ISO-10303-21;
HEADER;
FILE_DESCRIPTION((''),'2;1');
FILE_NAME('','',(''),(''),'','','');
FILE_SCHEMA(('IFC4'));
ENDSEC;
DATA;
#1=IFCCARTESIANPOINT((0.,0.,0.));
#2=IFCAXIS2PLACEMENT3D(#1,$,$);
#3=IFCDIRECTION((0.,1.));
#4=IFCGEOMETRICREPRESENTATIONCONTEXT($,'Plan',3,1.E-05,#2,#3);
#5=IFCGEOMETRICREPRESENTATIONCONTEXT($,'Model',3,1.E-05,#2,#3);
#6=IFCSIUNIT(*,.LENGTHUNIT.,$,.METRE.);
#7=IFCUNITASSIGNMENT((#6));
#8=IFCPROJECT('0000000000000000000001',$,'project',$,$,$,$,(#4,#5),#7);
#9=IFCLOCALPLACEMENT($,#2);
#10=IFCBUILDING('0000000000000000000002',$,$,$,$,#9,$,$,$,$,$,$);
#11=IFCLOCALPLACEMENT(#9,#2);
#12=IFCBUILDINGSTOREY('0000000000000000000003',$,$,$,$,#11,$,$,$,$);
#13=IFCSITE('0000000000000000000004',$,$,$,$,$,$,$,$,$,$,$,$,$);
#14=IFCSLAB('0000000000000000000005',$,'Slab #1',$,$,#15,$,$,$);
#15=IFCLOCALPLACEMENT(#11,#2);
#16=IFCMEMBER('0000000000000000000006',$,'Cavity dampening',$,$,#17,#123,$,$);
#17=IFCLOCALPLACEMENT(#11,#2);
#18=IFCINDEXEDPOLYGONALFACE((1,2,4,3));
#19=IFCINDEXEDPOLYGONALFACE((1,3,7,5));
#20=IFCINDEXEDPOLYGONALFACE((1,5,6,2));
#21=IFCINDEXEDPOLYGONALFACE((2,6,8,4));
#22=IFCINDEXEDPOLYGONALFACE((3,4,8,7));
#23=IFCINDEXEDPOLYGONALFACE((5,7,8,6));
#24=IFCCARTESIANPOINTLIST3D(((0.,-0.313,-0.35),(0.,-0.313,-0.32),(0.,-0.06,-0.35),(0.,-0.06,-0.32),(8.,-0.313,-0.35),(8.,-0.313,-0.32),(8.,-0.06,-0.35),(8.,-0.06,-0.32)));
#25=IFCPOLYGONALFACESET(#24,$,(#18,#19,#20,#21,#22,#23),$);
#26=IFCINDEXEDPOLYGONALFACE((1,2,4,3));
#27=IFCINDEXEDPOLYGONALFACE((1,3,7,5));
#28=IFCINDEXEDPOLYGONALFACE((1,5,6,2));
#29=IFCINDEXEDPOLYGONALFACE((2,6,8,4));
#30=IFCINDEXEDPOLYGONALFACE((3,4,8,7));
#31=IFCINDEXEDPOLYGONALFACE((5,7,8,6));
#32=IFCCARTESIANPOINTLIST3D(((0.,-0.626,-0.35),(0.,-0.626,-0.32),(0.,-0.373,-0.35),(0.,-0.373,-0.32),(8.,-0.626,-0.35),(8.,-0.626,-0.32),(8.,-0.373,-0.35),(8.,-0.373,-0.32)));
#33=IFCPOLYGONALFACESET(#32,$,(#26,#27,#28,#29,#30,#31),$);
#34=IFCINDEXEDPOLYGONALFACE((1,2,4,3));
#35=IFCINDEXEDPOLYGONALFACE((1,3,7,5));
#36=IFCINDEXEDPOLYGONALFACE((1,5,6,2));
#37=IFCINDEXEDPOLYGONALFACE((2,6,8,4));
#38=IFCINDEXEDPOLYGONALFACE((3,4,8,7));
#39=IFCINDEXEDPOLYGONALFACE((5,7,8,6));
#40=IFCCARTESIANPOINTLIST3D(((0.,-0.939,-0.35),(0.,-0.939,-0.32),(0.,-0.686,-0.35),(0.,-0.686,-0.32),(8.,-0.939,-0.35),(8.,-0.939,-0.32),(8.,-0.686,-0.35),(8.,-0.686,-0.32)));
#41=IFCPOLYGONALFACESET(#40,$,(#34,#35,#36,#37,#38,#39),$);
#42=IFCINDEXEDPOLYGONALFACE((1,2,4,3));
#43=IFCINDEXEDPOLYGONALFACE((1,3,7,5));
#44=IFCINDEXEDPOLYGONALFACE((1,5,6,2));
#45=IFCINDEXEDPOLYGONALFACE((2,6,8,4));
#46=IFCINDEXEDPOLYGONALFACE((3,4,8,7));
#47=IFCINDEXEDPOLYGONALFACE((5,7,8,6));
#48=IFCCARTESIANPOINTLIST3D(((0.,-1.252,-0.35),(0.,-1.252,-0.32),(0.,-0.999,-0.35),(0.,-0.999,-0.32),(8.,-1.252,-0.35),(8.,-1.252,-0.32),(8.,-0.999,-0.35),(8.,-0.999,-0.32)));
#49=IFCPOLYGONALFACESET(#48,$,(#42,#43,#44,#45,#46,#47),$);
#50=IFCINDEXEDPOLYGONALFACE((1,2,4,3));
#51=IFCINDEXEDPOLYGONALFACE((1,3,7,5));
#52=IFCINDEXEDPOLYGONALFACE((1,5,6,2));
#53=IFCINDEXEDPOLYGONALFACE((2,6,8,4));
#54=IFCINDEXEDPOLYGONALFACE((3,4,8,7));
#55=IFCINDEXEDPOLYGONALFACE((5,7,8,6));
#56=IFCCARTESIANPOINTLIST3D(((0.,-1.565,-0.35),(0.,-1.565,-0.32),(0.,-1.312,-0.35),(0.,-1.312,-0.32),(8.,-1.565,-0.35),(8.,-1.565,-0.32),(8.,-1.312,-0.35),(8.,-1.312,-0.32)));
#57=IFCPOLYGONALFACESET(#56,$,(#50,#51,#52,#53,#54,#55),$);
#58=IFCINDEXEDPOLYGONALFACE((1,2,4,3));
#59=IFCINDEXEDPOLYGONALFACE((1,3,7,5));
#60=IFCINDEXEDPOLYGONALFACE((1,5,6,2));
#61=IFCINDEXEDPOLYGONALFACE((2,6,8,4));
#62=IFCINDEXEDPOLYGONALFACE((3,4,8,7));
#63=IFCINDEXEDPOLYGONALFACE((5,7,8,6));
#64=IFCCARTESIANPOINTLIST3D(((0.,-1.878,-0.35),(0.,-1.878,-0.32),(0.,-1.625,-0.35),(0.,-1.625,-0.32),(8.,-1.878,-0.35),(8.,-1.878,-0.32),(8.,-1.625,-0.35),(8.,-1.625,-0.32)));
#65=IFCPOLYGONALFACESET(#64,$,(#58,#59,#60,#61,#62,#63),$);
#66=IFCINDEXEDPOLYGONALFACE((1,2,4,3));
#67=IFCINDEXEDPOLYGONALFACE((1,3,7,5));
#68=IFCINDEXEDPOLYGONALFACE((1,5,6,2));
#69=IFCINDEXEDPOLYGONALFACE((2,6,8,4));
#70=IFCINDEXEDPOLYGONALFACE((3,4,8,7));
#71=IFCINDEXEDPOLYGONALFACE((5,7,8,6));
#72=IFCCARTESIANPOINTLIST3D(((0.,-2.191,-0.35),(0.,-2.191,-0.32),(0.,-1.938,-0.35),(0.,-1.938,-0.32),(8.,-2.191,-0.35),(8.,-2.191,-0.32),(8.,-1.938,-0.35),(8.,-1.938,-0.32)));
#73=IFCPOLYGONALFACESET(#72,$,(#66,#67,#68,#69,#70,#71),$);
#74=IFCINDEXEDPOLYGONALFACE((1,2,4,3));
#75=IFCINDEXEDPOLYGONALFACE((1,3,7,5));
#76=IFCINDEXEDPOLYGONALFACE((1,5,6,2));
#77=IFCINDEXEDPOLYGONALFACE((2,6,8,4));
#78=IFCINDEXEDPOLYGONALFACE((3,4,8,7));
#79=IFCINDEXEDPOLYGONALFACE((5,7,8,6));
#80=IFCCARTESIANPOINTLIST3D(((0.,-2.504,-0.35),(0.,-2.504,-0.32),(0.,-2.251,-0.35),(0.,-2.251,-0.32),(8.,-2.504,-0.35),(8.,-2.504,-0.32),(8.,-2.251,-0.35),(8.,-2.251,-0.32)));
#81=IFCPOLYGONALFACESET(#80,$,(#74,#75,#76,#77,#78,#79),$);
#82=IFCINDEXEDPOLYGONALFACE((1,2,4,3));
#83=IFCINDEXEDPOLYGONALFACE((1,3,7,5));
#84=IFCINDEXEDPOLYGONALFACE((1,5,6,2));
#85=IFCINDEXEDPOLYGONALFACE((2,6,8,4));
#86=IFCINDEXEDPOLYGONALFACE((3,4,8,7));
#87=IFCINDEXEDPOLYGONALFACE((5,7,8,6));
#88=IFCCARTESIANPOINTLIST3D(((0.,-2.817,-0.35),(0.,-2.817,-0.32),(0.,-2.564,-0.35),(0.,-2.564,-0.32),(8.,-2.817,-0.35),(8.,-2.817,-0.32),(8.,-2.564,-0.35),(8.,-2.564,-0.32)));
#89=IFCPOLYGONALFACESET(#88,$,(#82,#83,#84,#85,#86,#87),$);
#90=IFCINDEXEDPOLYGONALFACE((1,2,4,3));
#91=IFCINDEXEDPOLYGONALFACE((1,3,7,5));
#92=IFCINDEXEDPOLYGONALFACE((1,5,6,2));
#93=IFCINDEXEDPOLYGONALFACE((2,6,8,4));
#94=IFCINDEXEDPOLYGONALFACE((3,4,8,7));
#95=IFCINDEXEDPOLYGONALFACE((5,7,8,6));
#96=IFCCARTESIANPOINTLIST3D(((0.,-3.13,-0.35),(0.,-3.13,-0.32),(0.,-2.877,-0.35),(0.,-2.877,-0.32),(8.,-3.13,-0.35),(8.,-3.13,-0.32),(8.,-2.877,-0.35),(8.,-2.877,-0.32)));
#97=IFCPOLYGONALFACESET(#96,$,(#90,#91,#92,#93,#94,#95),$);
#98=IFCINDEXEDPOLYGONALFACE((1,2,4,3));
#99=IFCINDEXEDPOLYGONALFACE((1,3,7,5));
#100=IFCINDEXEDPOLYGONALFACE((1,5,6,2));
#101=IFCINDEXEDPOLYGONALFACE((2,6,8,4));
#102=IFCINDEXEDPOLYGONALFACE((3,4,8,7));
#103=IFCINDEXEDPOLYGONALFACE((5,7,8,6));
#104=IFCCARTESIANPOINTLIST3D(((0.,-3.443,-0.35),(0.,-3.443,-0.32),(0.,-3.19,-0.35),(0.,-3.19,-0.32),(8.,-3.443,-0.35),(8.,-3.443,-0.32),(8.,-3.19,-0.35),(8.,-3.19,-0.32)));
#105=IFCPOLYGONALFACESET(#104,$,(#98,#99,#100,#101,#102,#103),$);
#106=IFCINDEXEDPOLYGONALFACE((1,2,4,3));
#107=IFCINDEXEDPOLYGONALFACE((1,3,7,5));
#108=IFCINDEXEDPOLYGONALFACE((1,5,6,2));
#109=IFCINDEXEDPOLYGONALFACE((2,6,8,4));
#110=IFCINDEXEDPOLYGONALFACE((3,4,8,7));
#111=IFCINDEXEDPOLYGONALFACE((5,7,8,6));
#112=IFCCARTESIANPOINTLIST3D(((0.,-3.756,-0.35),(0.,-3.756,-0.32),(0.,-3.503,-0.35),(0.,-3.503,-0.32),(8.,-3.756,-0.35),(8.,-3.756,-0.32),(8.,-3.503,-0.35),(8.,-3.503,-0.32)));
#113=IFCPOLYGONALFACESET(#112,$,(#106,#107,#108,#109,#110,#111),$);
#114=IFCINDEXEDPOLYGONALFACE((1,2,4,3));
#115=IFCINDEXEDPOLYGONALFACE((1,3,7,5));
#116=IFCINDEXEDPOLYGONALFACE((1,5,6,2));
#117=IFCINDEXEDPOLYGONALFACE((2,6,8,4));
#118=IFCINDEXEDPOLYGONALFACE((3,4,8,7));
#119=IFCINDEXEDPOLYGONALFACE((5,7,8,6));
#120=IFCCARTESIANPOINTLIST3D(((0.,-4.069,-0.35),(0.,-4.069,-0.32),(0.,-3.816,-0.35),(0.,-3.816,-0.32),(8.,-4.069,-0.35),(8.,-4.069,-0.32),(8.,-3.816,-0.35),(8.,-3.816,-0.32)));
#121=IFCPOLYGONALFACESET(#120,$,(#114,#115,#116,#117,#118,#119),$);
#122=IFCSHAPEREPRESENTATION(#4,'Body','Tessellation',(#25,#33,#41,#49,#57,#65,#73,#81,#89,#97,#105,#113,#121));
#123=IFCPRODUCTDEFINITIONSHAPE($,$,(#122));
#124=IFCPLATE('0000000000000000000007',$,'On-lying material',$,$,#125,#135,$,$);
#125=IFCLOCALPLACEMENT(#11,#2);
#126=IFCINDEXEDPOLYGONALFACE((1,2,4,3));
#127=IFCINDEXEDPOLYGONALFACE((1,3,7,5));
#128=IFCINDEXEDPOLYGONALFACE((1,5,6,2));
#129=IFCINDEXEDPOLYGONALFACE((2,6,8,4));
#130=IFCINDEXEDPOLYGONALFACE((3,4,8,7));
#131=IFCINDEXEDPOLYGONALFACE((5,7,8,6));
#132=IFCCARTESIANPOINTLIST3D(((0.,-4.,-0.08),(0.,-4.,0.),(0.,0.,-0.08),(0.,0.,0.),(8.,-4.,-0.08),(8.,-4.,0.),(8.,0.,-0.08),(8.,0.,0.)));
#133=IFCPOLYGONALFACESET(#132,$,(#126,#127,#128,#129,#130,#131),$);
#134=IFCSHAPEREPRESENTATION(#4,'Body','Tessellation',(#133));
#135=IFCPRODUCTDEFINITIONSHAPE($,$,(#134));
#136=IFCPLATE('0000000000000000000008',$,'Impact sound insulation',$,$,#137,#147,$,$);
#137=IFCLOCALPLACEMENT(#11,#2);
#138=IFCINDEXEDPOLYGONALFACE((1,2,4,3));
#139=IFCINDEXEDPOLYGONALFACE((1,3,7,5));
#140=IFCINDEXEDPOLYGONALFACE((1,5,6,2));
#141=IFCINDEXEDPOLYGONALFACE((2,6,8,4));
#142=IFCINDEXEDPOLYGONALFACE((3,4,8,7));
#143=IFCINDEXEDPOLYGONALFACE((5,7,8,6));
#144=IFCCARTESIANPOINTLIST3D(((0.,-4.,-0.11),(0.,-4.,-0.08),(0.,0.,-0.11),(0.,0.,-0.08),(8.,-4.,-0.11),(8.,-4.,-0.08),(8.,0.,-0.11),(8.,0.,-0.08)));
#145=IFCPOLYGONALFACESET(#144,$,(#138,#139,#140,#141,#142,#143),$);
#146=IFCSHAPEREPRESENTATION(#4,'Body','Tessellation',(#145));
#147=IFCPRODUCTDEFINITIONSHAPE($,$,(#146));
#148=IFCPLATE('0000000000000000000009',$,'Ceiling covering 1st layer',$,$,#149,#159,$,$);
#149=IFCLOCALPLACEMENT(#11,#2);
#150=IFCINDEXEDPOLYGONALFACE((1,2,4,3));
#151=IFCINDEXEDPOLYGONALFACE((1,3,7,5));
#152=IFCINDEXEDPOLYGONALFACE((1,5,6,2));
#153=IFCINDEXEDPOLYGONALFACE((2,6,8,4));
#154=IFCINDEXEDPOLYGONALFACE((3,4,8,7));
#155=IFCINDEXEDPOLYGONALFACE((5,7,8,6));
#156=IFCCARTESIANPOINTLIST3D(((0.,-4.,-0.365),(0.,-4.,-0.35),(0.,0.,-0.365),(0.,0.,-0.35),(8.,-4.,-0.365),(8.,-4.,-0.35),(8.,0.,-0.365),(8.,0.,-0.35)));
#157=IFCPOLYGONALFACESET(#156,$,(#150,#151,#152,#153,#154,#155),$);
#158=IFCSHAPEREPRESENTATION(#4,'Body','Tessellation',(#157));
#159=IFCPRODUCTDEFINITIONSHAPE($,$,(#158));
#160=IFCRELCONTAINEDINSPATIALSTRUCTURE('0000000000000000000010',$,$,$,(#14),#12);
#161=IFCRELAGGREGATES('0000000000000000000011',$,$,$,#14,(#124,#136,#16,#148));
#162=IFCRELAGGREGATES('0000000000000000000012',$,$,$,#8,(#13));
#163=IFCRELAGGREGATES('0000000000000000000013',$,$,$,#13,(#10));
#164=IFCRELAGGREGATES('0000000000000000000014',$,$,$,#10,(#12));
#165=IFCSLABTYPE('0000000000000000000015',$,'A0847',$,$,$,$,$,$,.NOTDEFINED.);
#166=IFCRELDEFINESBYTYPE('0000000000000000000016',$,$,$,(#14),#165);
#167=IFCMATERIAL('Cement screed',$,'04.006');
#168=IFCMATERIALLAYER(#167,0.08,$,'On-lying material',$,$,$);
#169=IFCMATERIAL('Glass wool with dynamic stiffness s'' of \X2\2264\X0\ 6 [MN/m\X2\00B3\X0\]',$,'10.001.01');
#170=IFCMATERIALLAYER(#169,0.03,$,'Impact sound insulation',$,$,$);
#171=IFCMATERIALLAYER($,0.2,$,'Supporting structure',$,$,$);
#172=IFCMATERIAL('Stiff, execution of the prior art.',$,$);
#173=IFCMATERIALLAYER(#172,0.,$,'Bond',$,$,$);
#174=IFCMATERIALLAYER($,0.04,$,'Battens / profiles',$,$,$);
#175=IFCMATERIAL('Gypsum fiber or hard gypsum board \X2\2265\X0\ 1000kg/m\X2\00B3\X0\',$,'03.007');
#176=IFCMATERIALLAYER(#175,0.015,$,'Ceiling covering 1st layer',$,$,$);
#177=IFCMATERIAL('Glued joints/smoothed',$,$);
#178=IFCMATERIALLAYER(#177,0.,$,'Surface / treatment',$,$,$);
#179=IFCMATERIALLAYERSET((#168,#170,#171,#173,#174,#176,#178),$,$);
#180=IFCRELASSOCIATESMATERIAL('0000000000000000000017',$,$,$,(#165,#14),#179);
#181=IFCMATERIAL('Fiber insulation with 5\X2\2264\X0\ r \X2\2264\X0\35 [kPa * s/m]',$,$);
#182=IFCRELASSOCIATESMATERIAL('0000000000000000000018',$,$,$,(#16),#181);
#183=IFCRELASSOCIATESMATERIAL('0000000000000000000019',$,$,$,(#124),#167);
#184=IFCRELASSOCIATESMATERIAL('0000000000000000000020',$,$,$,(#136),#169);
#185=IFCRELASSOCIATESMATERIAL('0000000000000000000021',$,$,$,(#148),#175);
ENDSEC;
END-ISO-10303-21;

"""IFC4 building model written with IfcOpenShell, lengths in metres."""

from ifc_helpers import new_model, si_unit, direction, frame, frame_2d, origin, origin_with_axes, place, context, project, spatial, rectangle, extrude, material, layer, layer_set, type_object, element, aggregate, save


model = new_model("IFC4")

# Units and contexts
plan_context = context("Plan", 3, precision=1e-05, world=origin(), true_north=direction((0.0, 1.0)))
model_context = context("Model", 3, precision=1e-05, world=origin(), true_north=direction((0.0, 1.0)))
ifc_project = project(units=[si_unit("LENGTHUNIT", "METRE")], contexts=[plan_context, model_context])

# Site, building, storey
site = spatial("IfcSite", under=ifc_project)
building_placement = place(None, origin())
building = spatial("IfcBuilding", under=site, at=building_placement)
storey_placement = place(building_placement, origin())
storey = spatial("IfcBuildingStorey", under=building, at=storey_placement)

# Slab, member, plates
ifc_material_1 = material(Name="Cement screed", Category="04.006")
ifc_layer_1 = layer(ifc_material_1, 0.08, Name="On-lying material")
ifc_material_2 = material(Name="Glass wool with dynamic stiffness s' of ≤ 6 [MN/m³]", Category="10.001.01")
ifc_layer_2 = layer(ifc_material_2, 0.03, Name="Impact sound insulation")
ifc_layer_3 = layer(None, 0.2, Name="Supporting structure")
ifc_material_3 = material(Name="Stiff, execution of the prior art.")
ifc_layer_4 = layer(ifc_material_3, 0.0, Name="Bond")
ifc_layer_5 = layer(None, 0.04, Name="Battens / profiles")
ifc_material_4 = material(Name="Gypsum fiber or hard gypsum board ≥ 1000kg/m³", Category="03.007")
ifc_layer_6 = layer(ifc_material_4, 0.015, Name="Ceiling covering 1st layer")
ifc_material_5 = material(Name="Glued joints/smoothed")
ifc_layer_7 = layer(ifc_material_5, 0.0, Name="Surface / treatment")
ifc_layer_set = layer_set([ifc_layer_1, ifc_layer_2, ifc_layer_3, ifc_layer_4, ifc_layer_5, ifc_layer_6, ifc_layer_7])
slab_type = type_object("IfcSlabType", Name="A0847", PredefinedType="NOTDEFINED", material=ifc_layer_set)
slab_placement = place(None, frame((0.0, 0.0, 0.0), z_axis=(0.0, 0.0, -1.0), x_axis=(1.0, 0.0, 0.0)))
slab = element("IfcSlab", 1, at=slab_placement, inside=storey, type_object=slab_type, material=ifc_layer_set, Name="Slab #1")
ifc_material_6 = material(Name="Fiber insulation with 5≤ r ≤35 [kPa * s/m]")
member_1_placement = place(slab_placement, origin())
member_1 = element("IfcMember", 2, at=member_1_placement, material=ifc_material_6, Name="Cavity dampening", context=plan_context, shape_type="SweptSolid", body=[
    extrude(rectangle(XDim=0.253, YDim=0.03, at=frame_2d((0.1265, 0.015), x_axis=(1.0, 0.0))), frame((0.0, 0.06, 0.32), z_axis=(1.0, 0.0, 0.0), x_axis=(0.0, 1.0, 0.0)), (0.0, 0.0, 1.0), 8.0),
    extrude(rectangle(XDim=0.253, YDim=0.03, at=frame_2d((0.1265, 0.015), x_axis=(1.0, 0.0))), frame((0.0, 0.373, 0.32), z_axis=(1.0, 0.0, 0.0), x_axis=(0.0, 1.0, 0.0)), (0.0, 0.0, 1.0), 8.0),
    extrude(rectangle(XDim=0.253, YDim=0.03, at=frame_2d((0.1265, 0.015), x_axis=(1.0, 0.0))), frame((0.0, 0.686, 0.32), z_axis=(1.0, 0.0, 0.0), x_axis=(0.0, 1.0, 0.0)), (0.0, 0.0, 1.0), 8.0),
    extrude(rectangle(XDim=0.253, YDim=0.03, at=frame_2d((0.1265, 0.015), x_axis=(1.0, 0.0))), frame((0.0, 0.999, 0.32), z_axis=(1.0, 0.0, 0.0), x_axis=(0.0, 1.0, 0.0)), (0.0, 0.0, 1.0), 8.0),
    extrude(rectangle(XDim=0.253, YDim=0.03, at=frame_2d((0.1265, 0.015), x_axis=(1.0, 0.0))), frame((0.0, 1.312, 0.32), z_axis=(1.0, 0.0, 0.0), x_axis=(0.0, 1.0, 0.0)), (0.0, 0.0, 1.0), 8.0),
    extrude(rectangle(XDim=0.253, YDim=0.03, at=frame_2d((0.1265, 0.015), x_axis=(1.0, 0.0))), frame((0.0, 1.625, 0.32), z_axis=(1.0, 0.0, 0.0), x_axis=(0.0, 1.0, 0.0)), (0.0, 0.0, 1.0), 8.0),
    extrude(rectangle(XDim=0.253, YDim=0.03, at=frame_2d((0.1265, 0.015), x_axis=(1.0, 0.0))), frame((0.0, 1.938, 0.32), z_axis=(1.0, 0.0, 0.0), x_axis=(0.0, 1.0, 0.0)), (0.0, 0.0, 1.0), 8.0),
    extrude(rectangle(XDim=0.253, YDim=0.03, at=frame_2d((0.1265, 0.015), x_axis=(1.0, 0.0))), frame((0.0, 2.251, 0.32), z_axis=(1.0, 0.0, 0.0), x_axis=(0.0, 1.0, 0.0)), (0.0, 0.0, 1.0), 8.0),
    extrude(rectangle(XDim=0.253, YDim=0.03, at=frame_2d((0.1265, 0.015), x_axis=(1.0, 0.0))), frame((0.0, 2.564, 0.32), z_axis=(1.0, 0.0, 0.0), x_axis=(0.0, 1.0, 0.0)), (0.0, 0.0, 1.0), 8.0),
    extrude(rectangle(XDim=0.253, YDim=0.03, at=frame_2d((0.1265, 0.015), x_axis=(1.0, 0.0))), frame((0.0, 2.877, 0.32), z_axis=(1.0, 0.0, 0.0), x_axis=(0.0, 1.0, 0.0)), (0.0, 0.0, 1.0), 8.0),
    extrude(rectangle(XDim=0.253, YDim=0.03, at=frame_2d((0.1265, 0.015), x_axis=(1.0, 0.0))), frame((0.0, 3.19, 0.32), z_axis=(1.0, 0.0, 0.0), x_axis=(0.0, 1.0, 0.0)), (0.0, 0.0, 1.0), 8.0),
    extrude(rectangle(XDim=0.253, YDim=0.03, at=frame_2d((0.1265, 0.015), x_axis=(1.0, 0.0))), frame((0.0, 3.503, 0.32), z_axis=(1.0, 0.0, 0.0), x_axis=(0.0, 1.0, 0.0)), (0.0, 0.0, 1.0), 8.0),
    extrude(rectangle(XDim=0.253, YDim=0.03, at=frame_2d((0.1265, 0.015), x_axis=(1.0, 0.0))), frame((0.0, 3.816, 0.32), z_axis=(1.0, 0.0, 0.0), x_axis=(0.0, 1.0, 0.0)), (0.0, 0.0, 1.0), 8.0),
])
plate_1_placement = place(slab_placement, origin())
plate_1 = element("IfcPlate", 3, at=plate_1_placement, material=ifc_material_1, Name="On-lying material", context=plan_context, shape_type="SweptSolid", body=[
    extrude(rectangle(XDim=8.0, YDim=4.0, at=frame_2d((4.0, 2.0), x_axis=(1.0, 0.0))), origin_with_axes(), (0.0, 0.0, 1.0), 0.08),
])
plate_2_placement = place(slab_placement, origin())
plate_2 = element("IfcPlate", 4, at=plate_2_placement, material=ifc_material_2, Name="Impact sound insulation", context=plan_context, shape_type="SweptSolid", body=[
    extrude(rectangle(XDim=8.0, YDim=4.0, at=frame_2d((4.0, 2.0), x_axis=(1.0, 0.0))), frame((0.0, 0.0, 0.08), z_axis=(0.0, 0.0, 1.0), x_axis=(1.0, 0.0, 0.0)), (0.0, 0.0, 1.0), 0.03),
])
plate_3_placement = place(slab_placement, origin())
plate_3 = element("IfcPlate", 5, at=plate_3_placement, material=ifc_material_4, Name="Ceiling covering 1st layer", context=plan_context, shape_type="SweptSolid", body=[
    extrude(rectangle(XDim=8.0, YDim=4.0, at=frame_2d((4.0, 2.0), x_axis=(1.0, 0.0))), frame((0.0, 0.0, 0.35), z_axis=(0.0, 0.0, 1.0), x_axis=(1.0, 0.0, 0.0)), (0.0, 0.0, 1.0), 0.015),
])
aggregate(slab, [plate_1, plate_2, member_1, plate_3])

save(model, "model.ifc")
